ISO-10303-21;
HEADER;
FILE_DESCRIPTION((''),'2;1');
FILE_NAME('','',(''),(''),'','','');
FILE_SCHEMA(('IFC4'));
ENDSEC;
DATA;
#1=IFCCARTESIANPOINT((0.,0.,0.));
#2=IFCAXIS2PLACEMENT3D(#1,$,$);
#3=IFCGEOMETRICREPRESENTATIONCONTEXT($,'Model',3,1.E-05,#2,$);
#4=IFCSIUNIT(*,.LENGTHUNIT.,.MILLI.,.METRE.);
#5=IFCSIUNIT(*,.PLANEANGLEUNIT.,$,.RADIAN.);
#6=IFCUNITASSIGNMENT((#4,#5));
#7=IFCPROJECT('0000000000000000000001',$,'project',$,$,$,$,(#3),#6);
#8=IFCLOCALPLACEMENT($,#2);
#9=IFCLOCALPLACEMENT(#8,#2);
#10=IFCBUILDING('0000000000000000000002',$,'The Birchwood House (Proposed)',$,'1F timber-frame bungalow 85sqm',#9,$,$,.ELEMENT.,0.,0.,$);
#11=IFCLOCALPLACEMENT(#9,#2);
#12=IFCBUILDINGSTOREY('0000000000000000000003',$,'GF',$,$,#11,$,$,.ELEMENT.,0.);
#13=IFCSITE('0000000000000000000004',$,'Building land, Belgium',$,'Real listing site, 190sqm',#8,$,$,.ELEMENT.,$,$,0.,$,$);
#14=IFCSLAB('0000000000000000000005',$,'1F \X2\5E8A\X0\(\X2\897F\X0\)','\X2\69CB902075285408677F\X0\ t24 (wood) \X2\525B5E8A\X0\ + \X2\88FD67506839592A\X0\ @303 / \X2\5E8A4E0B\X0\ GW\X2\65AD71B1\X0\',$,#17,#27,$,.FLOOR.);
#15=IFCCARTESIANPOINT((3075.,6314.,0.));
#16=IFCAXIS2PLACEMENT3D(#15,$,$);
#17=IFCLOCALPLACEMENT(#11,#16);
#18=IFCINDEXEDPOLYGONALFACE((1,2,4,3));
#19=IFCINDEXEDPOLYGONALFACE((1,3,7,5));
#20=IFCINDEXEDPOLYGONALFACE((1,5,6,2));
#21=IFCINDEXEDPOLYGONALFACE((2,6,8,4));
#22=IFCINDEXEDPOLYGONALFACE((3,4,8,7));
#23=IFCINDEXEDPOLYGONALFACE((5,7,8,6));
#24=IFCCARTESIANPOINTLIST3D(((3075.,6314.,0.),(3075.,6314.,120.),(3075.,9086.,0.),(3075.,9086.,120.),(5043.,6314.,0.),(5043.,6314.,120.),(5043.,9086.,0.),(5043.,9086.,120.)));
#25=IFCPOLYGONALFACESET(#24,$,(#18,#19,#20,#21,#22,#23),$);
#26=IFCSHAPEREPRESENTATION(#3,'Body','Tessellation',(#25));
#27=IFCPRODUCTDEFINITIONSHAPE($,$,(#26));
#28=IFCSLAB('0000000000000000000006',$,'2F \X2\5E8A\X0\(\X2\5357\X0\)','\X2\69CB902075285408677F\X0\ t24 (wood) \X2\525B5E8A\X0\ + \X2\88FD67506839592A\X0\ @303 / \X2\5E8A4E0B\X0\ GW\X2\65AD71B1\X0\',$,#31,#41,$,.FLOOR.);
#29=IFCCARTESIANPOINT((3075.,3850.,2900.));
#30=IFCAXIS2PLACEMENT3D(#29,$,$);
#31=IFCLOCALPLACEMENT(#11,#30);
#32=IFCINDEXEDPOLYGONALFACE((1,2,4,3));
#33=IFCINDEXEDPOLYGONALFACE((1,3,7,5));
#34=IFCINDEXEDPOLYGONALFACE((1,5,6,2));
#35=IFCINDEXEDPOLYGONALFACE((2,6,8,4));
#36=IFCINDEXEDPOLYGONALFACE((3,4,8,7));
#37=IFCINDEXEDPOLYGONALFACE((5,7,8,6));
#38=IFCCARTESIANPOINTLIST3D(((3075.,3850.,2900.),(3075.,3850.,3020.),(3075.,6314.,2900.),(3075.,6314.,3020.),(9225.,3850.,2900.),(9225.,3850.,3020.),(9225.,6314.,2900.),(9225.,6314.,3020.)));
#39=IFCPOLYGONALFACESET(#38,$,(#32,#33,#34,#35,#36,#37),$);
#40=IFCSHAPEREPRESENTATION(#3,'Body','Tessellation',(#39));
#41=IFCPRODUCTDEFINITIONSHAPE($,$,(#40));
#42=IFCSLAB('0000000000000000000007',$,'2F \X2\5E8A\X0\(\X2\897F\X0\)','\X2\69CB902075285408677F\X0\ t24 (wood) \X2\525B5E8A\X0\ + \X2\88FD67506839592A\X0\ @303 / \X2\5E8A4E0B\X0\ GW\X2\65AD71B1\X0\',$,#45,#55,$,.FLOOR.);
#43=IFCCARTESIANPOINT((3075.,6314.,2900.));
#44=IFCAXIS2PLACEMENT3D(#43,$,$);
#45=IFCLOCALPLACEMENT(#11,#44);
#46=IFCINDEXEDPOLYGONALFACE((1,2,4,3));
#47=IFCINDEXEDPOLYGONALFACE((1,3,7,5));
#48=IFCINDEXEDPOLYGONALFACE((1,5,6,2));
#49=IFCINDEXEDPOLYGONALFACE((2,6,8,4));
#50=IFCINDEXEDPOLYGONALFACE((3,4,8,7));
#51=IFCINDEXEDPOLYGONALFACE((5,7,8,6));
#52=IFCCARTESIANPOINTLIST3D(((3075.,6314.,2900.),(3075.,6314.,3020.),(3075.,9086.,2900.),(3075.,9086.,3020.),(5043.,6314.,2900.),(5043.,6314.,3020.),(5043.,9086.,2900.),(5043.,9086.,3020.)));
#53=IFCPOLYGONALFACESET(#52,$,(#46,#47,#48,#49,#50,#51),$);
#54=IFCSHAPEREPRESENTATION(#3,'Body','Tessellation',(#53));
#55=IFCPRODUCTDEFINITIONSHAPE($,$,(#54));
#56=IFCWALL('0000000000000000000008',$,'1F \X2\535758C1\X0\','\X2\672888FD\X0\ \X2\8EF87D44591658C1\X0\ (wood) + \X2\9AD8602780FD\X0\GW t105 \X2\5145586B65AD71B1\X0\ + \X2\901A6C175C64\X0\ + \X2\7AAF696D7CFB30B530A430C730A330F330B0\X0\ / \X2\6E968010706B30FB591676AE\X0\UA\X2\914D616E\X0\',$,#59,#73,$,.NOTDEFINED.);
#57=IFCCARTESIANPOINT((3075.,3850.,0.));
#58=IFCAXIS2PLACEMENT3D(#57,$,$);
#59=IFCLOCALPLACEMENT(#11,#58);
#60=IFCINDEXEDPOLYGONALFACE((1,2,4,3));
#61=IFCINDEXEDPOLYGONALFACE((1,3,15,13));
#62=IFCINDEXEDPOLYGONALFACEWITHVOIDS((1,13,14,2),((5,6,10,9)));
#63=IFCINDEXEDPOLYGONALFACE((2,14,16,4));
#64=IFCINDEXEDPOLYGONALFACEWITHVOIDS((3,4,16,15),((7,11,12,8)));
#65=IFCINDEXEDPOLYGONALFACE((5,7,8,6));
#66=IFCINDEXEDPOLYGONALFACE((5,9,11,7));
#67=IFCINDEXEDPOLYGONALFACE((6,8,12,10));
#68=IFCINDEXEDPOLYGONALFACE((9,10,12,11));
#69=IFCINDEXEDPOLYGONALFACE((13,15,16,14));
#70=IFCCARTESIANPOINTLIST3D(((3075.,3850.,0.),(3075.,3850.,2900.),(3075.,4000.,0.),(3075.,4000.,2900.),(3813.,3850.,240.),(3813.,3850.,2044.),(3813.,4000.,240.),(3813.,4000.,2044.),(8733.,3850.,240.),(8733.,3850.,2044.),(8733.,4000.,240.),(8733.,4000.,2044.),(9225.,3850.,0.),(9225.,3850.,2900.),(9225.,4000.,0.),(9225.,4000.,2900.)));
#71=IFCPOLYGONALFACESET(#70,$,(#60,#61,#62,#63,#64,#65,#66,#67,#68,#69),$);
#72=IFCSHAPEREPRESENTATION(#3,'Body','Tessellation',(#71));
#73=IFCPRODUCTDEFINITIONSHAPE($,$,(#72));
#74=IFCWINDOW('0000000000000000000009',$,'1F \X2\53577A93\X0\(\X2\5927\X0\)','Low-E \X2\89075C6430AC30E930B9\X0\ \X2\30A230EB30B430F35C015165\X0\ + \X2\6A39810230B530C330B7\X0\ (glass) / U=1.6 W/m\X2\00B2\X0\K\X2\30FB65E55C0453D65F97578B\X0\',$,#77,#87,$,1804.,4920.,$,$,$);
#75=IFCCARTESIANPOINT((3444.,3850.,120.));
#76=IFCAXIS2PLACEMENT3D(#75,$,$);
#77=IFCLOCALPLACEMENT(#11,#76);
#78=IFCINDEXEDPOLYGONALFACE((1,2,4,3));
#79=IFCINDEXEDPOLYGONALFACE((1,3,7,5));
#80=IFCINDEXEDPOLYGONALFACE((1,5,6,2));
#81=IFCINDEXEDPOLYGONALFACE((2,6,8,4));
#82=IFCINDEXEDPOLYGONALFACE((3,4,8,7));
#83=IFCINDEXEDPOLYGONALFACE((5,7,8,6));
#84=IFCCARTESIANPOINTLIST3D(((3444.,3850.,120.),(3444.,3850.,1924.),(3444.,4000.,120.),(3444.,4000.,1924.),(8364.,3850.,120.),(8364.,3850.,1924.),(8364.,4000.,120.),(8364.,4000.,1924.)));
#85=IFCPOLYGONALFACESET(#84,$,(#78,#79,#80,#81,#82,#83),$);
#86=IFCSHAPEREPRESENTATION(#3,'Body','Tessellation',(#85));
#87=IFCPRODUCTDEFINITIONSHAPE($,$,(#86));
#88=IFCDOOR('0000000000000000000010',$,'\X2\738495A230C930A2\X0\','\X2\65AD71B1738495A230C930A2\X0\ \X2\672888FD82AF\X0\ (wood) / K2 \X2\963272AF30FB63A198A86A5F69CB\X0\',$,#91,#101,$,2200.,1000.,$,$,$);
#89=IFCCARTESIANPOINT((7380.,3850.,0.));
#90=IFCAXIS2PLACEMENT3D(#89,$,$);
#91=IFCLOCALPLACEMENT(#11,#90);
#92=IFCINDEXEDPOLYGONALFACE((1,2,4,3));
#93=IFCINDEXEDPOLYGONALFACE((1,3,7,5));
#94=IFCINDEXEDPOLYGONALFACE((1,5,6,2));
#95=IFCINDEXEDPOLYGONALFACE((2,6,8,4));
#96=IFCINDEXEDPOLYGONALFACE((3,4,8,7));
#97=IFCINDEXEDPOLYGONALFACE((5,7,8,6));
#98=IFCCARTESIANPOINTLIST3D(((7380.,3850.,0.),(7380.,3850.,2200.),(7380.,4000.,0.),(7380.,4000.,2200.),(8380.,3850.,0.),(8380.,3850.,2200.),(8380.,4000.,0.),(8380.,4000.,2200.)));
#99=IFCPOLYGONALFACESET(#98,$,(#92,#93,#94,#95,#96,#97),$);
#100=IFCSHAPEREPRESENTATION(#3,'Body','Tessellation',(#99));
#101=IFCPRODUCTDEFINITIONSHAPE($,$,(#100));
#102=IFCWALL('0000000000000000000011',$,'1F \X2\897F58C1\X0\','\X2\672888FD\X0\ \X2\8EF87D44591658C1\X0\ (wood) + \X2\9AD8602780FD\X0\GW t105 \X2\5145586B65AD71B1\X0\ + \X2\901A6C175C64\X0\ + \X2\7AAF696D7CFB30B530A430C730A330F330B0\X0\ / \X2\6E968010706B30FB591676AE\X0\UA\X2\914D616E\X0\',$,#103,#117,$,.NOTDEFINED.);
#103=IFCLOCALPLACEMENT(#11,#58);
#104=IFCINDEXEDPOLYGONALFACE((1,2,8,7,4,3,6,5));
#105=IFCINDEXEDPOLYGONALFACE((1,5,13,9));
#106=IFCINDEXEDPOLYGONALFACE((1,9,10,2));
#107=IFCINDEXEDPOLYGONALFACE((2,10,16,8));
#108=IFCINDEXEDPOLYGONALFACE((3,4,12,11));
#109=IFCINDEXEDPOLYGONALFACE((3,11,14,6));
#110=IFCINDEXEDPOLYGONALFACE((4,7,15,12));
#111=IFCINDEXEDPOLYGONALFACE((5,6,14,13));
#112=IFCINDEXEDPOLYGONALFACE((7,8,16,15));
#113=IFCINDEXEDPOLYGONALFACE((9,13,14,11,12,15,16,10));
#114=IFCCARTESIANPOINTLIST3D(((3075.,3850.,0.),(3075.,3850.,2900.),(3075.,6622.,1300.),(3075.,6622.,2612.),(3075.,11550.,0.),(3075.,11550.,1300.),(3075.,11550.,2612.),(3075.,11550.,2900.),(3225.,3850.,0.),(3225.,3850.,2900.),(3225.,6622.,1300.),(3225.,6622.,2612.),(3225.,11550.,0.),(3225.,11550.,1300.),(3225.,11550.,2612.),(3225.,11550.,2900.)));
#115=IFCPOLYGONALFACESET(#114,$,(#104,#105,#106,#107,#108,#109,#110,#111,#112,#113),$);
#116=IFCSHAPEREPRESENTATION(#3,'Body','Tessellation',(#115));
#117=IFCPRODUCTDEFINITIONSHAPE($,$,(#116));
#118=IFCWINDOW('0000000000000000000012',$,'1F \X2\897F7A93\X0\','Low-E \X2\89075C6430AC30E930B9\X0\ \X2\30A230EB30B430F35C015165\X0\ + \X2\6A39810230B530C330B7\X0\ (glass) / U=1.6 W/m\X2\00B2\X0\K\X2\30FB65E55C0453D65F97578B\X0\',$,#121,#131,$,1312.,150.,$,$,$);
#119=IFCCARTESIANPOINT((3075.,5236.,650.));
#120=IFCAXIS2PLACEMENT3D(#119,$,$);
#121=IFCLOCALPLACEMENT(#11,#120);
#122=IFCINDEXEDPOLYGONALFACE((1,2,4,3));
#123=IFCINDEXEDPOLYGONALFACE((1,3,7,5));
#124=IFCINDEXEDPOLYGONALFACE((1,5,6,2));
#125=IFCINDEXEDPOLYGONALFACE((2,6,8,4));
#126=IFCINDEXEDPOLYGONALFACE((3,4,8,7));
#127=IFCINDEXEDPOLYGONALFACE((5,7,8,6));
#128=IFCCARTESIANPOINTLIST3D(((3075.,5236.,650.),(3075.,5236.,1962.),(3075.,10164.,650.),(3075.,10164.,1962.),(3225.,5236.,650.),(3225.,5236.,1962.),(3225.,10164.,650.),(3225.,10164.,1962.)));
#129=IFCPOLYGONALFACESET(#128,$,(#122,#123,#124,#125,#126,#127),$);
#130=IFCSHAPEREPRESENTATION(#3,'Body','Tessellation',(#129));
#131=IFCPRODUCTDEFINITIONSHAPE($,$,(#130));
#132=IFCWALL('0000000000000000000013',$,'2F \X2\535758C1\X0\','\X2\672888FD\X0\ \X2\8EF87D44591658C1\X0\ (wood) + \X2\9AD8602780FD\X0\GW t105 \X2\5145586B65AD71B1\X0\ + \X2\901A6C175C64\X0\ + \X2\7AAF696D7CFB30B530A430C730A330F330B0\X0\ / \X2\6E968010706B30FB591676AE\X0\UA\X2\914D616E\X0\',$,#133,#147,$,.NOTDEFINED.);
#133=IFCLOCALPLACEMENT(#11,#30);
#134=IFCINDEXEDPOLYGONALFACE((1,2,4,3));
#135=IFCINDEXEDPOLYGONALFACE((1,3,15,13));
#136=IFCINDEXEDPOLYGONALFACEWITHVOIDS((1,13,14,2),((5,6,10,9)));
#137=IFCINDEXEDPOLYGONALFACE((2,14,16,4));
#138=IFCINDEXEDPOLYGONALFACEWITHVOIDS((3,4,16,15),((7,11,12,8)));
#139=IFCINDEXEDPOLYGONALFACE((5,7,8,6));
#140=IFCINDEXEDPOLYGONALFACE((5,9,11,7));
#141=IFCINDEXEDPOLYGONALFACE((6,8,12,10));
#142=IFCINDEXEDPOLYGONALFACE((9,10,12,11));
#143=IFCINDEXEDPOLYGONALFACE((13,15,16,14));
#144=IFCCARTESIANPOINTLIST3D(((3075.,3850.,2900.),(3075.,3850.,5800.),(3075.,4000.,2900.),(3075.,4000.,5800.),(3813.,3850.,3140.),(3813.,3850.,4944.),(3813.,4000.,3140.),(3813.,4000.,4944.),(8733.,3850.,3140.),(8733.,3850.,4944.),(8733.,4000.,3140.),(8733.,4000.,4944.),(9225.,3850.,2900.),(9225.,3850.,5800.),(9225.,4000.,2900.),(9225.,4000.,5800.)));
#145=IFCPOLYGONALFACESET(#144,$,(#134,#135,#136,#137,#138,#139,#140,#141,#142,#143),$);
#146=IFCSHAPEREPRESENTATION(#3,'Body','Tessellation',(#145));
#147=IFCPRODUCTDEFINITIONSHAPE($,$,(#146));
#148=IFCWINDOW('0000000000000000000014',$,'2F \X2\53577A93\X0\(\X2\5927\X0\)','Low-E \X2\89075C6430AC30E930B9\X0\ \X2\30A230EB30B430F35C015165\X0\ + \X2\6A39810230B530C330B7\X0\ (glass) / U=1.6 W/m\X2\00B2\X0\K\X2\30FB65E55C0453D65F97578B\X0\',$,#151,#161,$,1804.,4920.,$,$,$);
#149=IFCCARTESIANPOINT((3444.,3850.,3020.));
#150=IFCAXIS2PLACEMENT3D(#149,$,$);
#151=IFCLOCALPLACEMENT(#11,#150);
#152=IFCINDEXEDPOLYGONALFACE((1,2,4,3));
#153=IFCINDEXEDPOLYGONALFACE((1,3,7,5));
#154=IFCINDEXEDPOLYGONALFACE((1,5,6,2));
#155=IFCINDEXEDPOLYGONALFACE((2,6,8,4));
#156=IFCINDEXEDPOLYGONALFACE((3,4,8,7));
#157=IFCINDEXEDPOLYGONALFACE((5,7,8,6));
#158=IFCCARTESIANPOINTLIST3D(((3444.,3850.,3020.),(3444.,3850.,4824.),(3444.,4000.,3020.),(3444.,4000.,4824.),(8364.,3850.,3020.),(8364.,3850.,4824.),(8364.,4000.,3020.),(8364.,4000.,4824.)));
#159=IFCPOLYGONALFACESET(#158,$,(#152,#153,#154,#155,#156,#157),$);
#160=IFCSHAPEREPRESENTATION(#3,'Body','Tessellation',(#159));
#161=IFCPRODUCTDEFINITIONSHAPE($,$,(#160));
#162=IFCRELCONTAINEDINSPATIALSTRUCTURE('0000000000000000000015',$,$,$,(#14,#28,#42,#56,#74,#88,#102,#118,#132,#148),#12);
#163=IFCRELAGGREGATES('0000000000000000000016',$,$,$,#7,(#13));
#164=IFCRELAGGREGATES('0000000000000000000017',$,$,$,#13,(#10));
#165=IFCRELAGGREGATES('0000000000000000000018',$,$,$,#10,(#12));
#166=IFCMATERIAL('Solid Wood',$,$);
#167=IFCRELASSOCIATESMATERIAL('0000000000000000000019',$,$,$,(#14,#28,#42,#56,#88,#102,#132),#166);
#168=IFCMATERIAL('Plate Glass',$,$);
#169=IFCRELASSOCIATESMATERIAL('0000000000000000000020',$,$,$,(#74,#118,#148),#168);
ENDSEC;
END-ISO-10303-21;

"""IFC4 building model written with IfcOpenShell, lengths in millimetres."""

from ifc_helpers import new_model, si_unit, frame, frame_2d, origin, place, context, project, spatial, rectangle, extrude, material, element, fill, save


model = new_model("IFC4")

# Units and contexts
model_context = context("Model", 3, precision=1e-05, world=origin())
ifc_project = project(units=[si_unit("LENGTHUNIT", "METRE", prefix="MILLI"), si_unit("PLANEANGLEUNIT", "RADIAN")], contexts=[model_context])

# Site, building, storey
site_placement = place(None, origin())
site = spatial("IfcSite", under=ifc_project, at=site_placement, Name="Building land, Belgium", ObjectType="Real listing site, 190sqm", CompositionType="ELEMENT", RefElevation=0.0)
building_placement = place(site_placement, origin())
building = spatial("IfcBuilding", under=site, at=building_placement, Name="The Birchwood House (Proposed)", ObjectType="1F timber-frame bungalow 85sqm", CompositionType="ELEMENT", ElevationOfRefHeight=0.0, ElevationOfTerrain=0.0)
storey_placement = place(building_placement, origin())
storey = spatial("IfcBuildingStorey", under=building, at=storey_placement, Name="GF", CompositionType="ELEMENT", Elevation=0.0)

# Slabs
ifc_material_1 = material(Name="Solid Wood")
slab_1_placement = place(storey_placement, frame((3075.0, 6314.0, 0.0)))
element("IfcSlab", 1, at=slab_1_placement, inside=storey, material=ifc_material_1, Name="1F 床(西)", Description="構造用合板 t24 (wood) 剛床 + 製材根太 @303 / 床下 GW断熱", PredefinedType="FLOOR", context=model_context, shape_type="SweptSolid", body=[
    extrude(rectangle(XDim=1968.0, YDim=2772.0, at=frame_2d((984.0, 1386.0))), frame((3075.0, 6314.0, 0.0)), (0.0, 0.0, 1.0), 120.0),
])
slab_2_placement = place(storey_placement, frame((3075.0, 3850.0, 2900.0)))
element("IfcSlab", 2, at=slab_2_placement, inside=storey, material=ifc_material_1, Name="2F 床(南)", Description="構造用合板 t24 (wood) 剛床 + 製材根太 @303 / 床下 GW断熱", PredefinedType="FLOOR", context=model_context, shape_type="SweptSolid", body=[
    extrude(rectangle(XDim=6150.0, YDim=2464.0, at=frame_2d((3075.0, 1232.0))), frame((3075.0, 3850.0, 2900.0)), (0.0, 0.0, 1.0), 120.0),
])
slab_3_placement = place(storey_placement, frame((3075.0, 6314.0, 2900.0)))
element("IfcSlab", 3, at=slab_3_placement, inside=storey, material=ifc_material_1, Name="2F 床(西)", Description="構造用合板 t24 (wood) 剛床 + 製材根太 @303 / 床下 GW断熱", PredefinedType="FLOOR", context=model_context, shape_type="SweptSolid", body=[
    extrude(rectangle(XDim=1968.0, YDim=2772.0, at=frame_2d((984.0, 1386.0))), frame((3075.0, 6314.0, 2900.0)), (0.0, 0.0, 1.0), 120.0),
])

# Wall, openings, window, door
wall_1_placement = place(storey_placement, frame((3075.0, 3850.0, 0.0)))
wall_1 = element("IfcWall", 4, at=wall_1_placement, inside=storey, material=ifc_material_1, Name="1F 南壁", Description="木製 軸組外壁 (wood) + 高性能GW t105 充填断熱 + 通気層 + 窯業系サイディング / 準耐火・外皮UA配慮", PredefinedType="NOTDEFINED", context=model_context, shape_type="SweptSolid", body=[
    extrude(rectangle(XDim=6150.0, YDim=150.0, at=frame_2d((3075.0, 75.0))), frame((3075.0, 3850.0, 0.0)), (0.0, 0.0, 1.0), 2900.0),
])
opening_1_placement = place(storey_placement, frame((3444.0, 3850.0, 120.0)))
opening_1 = element("IfcOpeningElement", 5, at=opening_1_placement, cuts=wall_1, PredefinedType="NOTDEFINED", context=model_context, shape_type="SweptSolid", body=[
    extrude(rectangle(XDim=4920.0, YDim=150.0, at=frame_2d((2460.0, 75.0))), frame((3444.0, 3850.0, 120.0)), (0.0, 0.0, 1.0), 1804.0),
])
opening_2_placement = place(storey_placement, frame((7380.0, 3850.0, 0.0)))
opening_2 = element("IfcOpeningElement", 6, at=opening_2_placement, cuts=wall_1, PredefinedType="NOTDEFINED", context=model_context, shape_type="SweptSolid", body=[
    extrude(rectangle(XDim=1000.0, YDim=150.0, at=frame_2d((500.0, 75.0))), frame((7380.0, 3850.0, 0.0)), (0.0, 0.0, 1.0), 2200.0),
])
ifc_material_2 = material(Name="Plate Glass")
window_1_placement = place(storey_placement, frame((3444.0, 3850.0, 120.0)))
window_1 = element("IfcWindow", 7, at=window_1_placement, inside=storey, material=ifc_material_2, Name="1F 南窓(大)", Description="Low-E 複層ガラス アルゴン封入 + 樹脂サッシ (glass) / U=1.6 W/m²K・日射取得型", OverallHeight=1804.0, OverallWidth=4920.0, context=model_context, shape_type="SweptSolid", body=[
    extrude(rectangle(XDim=4920.0, YDim=150.0, at=frame_2d((2460.0, 75.0))), frame((3444.0, 3850.0, 120.0)), (0.0, 0.0, 1.0), 1804.0),
])
fill(opening_1, window_1)
door_placement = place(storey_placement, frame((7380.0, 3850.0, 0.0)))
door = element("IfcDoor", 8, at=door_placement, inside=storey, material=ifc_material_1, Name="玄関ドア", Description="断熱玄関ドア 木製芯 (wood) / K2 防犯・採風機構", OverallHeight=2200.0, OverallWidth=1000.0, context=model_context, shape_type="SweptSolid", body=[
    extrude(rectangle(XDim=1000.0, YDim=150.0, at=frame_2d((500.0, 75.0))), frame((7380.0, 3850.0, 0.0)), (0.0, 0.0, 1.0), 2200.0),
])
fill(opening_2, door)

# Walls, openings, windows
wall_2_placement = place(storey_placement, frame((3075.0, 3850.0, 0.0)))
wall_2 = element("IfcWall", 9, at=wall_2_placement, inside=storey, material=ifc_material_1, Name="1F 西壁", Description="木製 軸組外壁 (wood) + 高性能GW t105 充填断熱 + 通気層 + 窯業系サイディング / 準耐火・外皮UA配慮", PredefinedType="NOTDEFINED", context=model_context, shape_type="SweptSolid", body=[
    extrude(rectangle(XDim=150.0, YDim=7700.0, at=frame_2d((75.0, 3850.0))), frame((3075.0, 3850.0, 0.0)), (0.0, 0.0, 1.0), 2900.0),
])
opening_3_placement = place(storey_placement, frame((3075.0, 5236.0, 650.0)))
opening_3 = element("IfcOpeningElement", 10, at=opening_3_placement, cuts=wall_2, PredefinedType="NOTDEFINED", context=model_context, shape_type="SweptSolid", body=[
    extrude(rectangle(XDim=150.0, YDim=4928.0, at=frame_2d((75.0, 2464.0))), frame((3075.0, 5236.0, 650.0)), (0.0, 0.0, 1.0), 1312.0),
])
window_2_placement = place(storey_placement, frame((3075.0, 5236.0, 650.0)))
window_2 = element("IfcWindow", 11, at=window_2_placement, inside=storey, material=ifc_material_2, Name="1F 西窓", Description="Low-E 複層ガラス アルゴン封入 + 樹脂サッシ (glass) / U=1.6 W/m²K・日射取得型", OverallHeight=1312.0, OverallWidth=150.0, context=model_context, shape_type="SweptSolid", body=[
    extrude(rectangle(XDim=150.0, YDim=4928.0, at=frame_2d((75.0, 2464.0))), frame((3075.0, 5236.0, 650.0)), (0.0, 0.0, 1.0), 1312.0),
])
fill(opening_3, window_2)
wall_3_placement = place(storey_placement, frame((3075.0, 3850.0, 2900.0)))
wall_3 = element("IfcWall", 12, at=wall_3_placement, inside=storey, material=ifc_material_1, Name="2F 南壁", Description="木製 軸組外壁 (wood) + 高性能GW t105 充填断熱 + 通気層 + 窯業系サイディング / 準耐火・外皮UA配慮", PredefinedType="NOTDEFINED", context=model_context, shape_type="SweptSolid", body=[
    extrude(rectangle(XDim=6150.0, YDim=150.0, at=frame_2d((3075.0, 75.0))), frame((3075.0, 3850.0, 2900.0)), (0.0, 0.0, 1.0), 2900.0),
])
opening_4_placement = place(storey_placement, frame((3444.0, 3850.0, 3020.0)))
opening_4 = element("IfcOpeningElement", 13, at=opening_4_placement, cuts=wall_3, PredefinedType="NOTDEFINED", context=model_context, shape_type="SweptSolid", body=[
    extrude(rectangle(XDim=4920.0, YDim=150.0, at=frame_2d((2460.0, 75.0))), frame((3444.0, 3850.0, 3020.0)), (0.0, 0.0, 1.0), 1804.0),
])
window_3_placement = place(storey_placement, frame((3444.0, 3850.0, 3020.0)))
window_3 = element("IfcWindow", 14, at=window_3_placement, inside=storey, material=ifc_material_2, Name="2F 南窓(大)", Description="Low-E 複層ガラス アルゴン封入 + 樹脂サッシ (glass) / U=1.6 W/m²K・日射取得型", OverallHeight=1804.0, OverallWidth=4920.0, context=model_context, shape_type="SweptSolid", body=[
    extrude(rectangle(XDim=4920.0, YDim=150.0, at=frame_2d((2460.0, 75.0))), frame((3444.0, 3850.0, 3020.0)), (0.0, 0.0, 1.0), 1804.0),
])
fill(opening_4, window_3)

save(model, "model.ifc")
